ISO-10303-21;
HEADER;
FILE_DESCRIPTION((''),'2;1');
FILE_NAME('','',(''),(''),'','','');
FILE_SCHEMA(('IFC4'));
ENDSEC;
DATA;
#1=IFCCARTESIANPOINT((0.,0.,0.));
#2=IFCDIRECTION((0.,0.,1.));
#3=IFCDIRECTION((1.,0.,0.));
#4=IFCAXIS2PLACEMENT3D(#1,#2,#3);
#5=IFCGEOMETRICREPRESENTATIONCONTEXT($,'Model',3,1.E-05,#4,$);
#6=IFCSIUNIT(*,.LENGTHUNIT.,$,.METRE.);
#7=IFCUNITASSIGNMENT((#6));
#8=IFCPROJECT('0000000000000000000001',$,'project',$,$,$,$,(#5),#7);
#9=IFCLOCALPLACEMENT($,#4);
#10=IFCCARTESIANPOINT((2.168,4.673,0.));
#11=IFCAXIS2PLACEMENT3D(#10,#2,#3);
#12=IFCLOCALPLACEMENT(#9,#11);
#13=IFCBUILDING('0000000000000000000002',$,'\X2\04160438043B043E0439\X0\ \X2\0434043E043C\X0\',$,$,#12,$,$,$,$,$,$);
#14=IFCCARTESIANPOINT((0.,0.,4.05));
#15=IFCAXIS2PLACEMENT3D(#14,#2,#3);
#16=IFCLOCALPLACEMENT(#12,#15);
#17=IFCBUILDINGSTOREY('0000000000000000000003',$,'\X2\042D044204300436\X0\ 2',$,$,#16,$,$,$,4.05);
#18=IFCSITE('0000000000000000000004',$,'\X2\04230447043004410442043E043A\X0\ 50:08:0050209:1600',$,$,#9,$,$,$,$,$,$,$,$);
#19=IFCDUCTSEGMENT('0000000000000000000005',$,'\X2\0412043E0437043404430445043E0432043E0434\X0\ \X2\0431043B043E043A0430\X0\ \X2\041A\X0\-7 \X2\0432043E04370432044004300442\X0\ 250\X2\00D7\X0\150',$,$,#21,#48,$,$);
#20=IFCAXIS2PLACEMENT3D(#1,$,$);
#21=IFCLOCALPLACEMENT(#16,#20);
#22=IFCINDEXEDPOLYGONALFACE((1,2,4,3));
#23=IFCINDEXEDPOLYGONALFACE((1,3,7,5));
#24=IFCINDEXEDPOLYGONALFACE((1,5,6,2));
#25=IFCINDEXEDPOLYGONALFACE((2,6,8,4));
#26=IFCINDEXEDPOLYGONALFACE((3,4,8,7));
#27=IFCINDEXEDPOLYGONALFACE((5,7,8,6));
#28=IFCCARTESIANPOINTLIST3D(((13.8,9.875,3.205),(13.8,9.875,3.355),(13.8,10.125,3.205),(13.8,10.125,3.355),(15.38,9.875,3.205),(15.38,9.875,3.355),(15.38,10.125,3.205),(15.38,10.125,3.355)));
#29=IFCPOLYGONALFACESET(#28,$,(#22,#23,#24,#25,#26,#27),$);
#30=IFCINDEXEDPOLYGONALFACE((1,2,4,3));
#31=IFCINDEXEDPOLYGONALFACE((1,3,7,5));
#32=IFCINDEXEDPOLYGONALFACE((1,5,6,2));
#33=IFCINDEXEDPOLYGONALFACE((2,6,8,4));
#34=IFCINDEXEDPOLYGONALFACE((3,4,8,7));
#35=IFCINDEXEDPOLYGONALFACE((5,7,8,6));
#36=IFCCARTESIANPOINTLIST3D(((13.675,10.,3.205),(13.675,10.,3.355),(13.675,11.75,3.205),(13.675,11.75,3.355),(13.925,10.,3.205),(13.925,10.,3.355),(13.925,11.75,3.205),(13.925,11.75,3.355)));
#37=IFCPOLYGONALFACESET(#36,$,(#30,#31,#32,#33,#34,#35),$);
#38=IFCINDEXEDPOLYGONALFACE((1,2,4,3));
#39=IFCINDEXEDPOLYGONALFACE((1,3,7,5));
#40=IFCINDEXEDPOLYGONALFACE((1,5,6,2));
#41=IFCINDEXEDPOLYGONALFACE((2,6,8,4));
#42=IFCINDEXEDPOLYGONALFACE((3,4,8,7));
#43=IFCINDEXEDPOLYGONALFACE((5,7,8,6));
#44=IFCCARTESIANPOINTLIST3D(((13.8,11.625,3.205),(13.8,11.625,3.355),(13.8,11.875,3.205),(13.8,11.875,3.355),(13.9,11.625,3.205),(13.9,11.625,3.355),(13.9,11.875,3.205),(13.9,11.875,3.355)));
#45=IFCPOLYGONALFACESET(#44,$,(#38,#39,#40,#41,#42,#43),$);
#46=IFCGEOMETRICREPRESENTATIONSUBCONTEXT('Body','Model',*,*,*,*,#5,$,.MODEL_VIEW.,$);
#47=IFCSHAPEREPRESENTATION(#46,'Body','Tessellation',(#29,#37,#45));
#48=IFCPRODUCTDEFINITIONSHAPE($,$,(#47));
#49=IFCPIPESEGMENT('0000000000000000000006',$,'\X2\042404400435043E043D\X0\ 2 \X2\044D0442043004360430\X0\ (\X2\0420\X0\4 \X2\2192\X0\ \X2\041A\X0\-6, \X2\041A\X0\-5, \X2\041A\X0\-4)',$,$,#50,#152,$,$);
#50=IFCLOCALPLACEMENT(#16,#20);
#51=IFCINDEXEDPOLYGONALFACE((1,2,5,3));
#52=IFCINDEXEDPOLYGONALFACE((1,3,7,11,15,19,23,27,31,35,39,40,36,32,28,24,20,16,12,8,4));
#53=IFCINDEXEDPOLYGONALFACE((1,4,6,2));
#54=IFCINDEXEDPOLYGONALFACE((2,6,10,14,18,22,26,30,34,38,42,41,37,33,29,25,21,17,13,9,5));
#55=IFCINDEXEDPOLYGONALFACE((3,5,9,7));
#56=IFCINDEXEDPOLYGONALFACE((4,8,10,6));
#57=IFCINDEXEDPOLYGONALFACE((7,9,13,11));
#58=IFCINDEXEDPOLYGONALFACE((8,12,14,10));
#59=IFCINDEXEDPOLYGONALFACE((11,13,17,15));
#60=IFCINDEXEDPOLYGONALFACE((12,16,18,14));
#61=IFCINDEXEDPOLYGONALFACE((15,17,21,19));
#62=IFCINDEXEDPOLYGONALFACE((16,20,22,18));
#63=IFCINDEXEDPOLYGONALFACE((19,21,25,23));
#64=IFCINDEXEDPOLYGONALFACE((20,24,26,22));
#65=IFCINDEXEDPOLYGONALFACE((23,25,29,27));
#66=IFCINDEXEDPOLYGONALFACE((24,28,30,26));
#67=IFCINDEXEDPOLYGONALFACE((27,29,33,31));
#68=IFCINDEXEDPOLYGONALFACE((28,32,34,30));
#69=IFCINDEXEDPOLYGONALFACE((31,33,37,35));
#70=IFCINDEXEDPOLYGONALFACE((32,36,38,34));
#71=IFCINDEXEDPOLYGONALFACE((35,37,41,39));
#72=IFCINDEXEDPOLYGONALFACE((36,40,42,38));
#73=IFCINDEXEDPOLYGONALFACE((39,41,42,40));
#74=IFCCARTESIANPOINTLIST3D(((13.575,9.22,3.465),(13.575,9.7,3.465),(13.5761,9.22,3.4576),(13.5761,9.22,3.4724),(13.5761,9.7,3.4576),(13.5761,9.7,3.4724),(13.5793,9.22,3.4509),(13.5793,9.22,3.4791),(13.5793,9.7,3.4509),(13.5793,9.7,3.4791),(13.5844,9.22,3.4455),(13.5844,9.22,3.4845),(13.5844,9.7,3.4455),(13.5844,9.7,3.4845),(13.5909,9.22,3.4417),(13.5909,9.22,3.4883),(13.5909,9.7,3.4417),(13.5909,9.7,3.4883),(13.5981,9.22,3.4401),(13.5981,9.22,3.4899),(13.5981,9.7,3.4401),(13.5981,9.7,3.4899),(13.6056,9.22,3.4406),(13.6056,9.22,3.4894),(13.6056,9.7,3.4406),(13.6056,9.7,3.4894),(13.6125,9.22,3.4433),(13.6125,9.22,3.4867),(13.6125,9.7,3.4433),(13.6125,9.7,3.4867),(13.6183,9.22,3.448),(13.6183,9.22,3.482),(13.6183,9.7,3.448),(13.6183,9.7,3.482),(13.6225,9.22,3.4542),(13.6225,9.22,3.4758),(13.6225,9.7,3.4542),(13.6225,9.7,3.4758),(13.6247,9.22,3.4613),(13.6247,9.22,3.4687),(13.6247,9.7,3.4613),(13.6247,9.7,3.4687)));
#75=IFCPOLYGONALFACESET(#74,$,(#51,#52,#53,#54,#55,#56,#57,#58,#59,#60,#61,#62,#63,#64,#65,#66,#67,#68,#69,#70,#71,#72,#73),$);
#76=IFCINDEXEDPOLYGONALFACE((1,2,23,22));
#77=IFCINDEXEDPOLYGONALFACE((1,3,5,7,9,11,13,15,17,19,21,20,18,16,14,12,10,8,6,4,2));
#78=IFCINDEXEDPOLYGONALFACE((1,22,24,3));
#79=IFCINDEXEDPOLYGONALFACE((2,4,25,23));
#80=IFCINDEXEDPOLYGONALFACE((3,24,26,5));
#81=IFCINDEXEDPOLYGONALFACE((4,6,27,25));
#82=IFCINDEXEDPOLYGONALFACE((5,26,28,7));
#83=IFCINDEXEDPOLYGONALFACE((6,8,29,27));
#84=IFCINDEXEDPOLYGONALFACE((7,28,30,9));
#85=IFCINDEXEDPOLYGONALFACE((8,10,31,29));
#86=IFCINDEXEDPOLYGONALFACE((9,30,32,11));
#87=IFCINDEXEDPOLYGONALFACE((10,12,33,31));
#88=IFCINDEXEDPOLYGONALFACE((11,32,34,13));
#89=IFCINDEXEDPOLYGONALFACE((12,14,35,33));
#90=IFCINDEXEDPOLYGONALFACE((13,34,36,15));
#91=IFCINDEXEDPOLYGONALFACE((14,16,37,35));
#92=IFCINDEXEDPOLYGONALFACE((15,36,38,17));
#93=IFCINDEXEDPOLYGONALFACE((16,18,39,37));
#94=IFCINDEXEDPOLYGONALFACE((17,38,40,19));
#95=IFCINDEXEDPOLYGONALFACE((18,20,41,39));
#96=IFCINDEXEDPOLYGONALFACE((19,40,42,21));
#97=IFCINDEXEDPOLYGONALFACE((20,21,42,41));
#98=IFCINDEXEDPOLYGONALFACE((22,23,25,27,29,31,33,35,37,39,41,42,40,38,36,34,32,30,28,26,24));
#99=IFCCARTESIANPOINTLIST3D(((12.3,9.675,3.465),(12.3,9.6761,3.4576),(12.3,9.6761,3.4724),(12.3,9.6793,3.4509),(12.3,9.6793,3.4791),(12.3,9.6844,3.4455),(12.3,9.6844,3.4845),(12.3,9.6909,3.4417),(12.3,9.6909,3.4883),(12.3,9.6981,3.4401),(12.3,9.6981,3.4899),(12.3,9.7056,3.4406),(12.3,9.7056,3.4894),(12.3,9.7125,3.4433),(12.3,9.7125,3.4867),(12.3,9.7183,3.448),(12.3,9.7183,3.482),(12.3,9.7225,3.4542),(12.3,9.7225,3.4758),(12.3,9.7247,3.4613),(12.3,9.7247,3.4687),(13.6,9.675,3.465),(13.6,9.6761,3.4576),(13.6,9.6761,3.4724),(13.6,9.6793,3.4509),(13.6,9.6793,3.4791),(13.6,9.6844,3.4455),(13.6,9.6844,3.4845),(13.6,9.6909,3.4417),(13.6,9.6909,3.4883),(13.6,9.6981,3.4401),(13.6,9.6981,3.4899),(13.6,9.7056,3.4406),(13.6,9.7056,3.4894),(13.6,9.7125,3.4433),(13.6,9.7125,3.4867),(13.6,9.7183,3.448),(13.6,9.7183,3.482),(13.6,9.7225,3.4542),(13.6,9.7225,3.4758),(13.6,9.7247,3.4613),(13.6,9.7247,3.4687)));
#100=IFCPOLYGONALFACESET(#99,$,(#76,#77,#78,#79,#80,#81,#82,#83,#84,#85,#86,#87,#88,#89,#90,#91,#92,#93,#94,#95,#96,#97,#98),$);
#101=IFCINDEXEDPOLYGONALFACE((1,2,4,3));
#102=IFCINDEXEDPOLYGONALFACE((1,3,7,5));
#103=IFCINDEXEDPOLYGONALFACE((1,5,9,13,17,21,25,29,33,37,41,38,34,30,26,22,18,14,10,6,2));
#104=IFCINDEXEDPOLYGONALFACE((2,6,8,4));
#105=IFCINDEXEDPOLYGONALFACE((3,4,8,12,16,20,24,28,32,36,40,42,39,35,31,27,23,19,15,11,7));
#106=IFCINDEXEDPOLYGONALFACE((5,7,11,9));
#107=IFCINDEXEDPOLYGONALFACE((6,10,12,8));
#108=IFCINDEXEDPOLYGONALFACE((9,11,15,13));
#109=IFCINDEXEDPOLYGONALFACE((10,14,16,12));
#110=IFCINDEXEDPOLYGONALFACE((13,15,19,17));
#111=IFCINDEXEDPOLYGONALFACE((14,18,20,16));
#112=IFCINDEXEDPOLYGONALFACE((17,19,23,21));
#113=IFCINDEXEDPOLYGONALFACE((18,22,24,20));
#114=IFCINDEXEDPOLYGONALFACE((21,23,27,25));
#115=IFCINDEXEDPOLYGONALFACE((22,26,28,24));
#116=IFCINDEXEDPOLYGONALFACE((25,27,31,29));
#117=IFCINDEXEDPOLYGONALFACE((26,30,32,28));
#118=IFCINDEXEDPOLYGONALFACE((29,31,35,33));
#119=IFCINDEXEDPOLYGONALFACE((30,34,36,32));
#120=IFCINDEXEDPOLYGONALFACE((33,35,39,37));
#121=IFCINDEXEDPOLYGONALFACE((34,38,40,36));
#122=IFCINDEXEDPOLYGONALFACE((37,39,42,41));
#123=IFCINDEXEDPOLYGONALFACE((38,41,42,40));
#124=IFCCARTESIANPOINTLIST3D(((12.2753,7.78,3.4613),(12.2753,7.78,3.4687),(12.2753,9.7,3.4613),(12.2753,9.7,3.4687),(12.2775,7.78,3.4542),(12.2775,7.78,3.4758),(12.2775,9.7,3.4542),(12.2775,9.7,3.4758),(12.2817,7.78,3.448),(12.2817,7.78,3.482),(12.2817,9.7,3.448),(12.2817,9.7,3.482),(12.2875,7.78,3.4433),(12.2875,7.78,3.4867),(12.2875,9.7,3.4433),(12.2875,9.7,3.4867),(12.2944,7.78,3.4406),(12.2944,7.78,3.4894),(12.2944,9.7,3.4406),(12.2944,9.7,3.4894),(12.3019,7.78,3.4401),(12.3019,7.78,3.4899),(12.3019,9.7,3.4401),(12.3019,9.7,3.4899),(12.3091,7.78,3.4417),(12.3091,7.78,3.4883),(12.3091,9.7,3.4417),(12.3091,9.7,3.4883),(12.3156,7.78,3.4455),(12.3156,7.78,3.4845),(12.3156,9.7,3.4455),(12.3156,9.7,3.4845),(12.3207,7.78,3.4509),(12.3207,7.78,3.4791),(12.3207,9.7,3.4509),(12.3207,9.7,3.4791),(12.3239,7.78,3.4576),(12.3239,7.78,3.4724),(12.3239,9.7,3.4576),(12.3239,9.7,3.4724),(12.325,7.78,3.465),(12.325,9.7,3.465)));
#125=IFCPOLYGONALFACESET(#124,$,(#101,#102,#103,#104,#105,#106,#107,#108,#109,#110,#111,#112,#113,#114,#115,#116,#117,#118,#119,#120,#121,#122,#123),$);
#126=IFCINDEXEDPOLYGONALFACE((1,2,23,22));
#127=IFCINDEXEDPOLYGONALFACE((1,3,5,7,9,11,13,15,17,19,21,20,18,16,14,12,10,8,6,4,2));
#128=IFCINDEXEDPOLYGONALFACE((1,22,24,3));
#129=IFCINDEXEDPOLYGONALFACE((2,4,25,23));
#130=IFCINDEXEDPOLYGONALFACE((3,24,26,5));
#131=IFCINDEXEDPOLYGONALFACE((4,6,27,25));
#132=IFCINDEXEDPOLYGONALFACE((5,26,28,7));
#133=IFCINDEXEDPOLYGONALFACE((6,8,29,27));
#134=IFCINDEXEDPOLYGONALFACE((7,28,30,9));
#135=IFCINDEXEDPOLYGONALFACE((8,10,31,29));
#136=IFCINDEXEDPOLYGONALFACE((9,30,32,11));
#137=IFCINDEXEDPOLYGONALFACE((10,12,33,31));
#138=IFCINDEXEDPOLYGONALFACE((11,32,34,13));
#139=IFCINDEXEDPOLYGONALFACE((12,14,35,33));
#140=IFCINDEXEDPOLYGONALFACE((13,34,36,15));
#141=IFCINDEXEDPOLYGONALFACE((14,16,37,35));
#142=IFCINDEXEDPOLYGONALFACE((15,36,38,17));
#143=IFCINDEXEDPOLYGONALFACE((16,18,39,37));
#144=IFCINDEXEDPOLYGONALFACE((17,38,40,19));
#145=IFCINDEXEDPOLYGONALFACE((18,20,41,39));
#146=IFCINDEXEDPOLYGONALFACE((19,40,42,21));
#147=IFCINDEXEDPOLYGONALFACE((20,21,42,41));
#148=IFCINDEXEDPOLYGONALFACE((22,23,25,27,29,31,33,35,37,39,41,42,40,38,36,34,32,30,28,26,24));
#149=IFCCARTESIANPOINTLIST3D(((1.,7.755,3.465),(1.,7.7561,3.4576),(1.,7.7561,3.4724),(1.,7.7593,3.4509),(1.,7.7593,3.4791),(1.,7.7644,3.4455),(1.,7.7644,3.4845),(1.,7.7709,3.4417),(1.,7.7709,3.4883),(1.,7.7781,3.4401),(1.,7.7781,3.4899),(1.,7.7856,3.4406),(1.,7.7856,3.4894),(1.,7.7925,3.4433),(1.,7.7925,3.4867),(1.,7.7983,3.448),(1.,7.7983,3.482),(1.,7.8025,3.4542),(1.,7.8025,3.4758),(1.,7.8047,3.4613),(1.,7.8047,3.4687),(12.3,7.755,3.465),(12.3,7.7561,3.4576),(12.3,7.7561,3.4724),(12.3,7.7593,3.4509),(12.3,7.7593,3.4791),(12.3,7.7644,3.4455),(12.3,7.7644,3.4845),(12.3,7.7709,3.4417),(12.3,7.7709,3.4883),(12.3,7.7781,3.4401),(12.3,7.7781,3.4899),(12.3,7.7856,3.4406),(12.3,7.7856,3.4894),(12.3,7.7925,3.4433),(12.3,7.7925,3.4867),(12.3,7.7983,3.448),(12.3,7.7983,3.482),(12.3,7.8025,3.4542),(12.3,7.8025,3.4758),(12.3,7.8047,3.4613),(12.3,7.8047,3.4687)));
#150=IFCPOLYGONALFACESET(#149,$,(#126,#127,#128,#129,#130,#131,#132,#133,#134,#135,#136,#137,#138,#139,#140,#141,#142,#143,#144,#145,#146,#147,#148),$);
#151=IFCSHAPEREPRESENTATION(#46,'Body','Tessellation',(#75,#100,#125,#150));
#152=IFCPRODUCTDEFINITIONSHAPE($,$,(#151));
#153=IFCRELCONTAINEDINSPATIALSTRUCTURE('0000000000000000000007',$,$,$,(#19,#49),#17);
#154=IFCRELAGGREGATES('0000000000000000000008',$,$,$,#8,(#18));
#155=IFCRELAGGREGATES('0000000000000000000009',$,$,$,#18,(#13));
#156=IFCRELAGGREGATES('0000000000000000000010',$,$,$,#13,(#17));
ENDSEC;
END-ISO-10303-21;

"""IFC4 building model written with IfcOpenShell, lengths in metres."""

from ifc_helpers import new_model, si_unit, frame, origin_with_axes, origin_2d, place, context, subcontext, project, spatial, rectangle, circle, extrude, element, save


model = new_model("IFC4")

# Units and contexts
model_context = context("Model", 3, precision=1e-05, world=origin_with_axes())
body_context = subcontext(model_context, "Body", "Model", "MODEL_VIEW")
ifc_project = project(units=[si_unit("LENGTHUNIT", "METRE")], contexts=[model_context])

# Site, building, storey
site_placement = place(None, origin_with_axes())
site = spatial("IfcSite", under=ifc_project, at=site_placement, Name="Участок 50:08:0050209:1600")
building_placement = place(site_placement, frame((2.168, 4.673, 0.0), z_axis=(0.0, 0.0, 1.0), x_axis=(1.0, 0.0, 0.0)))
building = spatial("IfcBuilding", under=site, at=building_placement, Name="Жилой дом")
storey_placement = place(building_placement, frame((0.0, 0.0, 4.05), z_axis=(0.0, 0.0, 1.0), x_axis=(1.0, 0.0, 0.0)))
storey = spatial("IfcBuildingStorey", under=building, at=storey_placement, Name="Этаж 2", Elevation=4.05)

# Duct segment
duct_segment_1_placement = place(storey_placement, frame((0.0, 0.0, -4.05), z_axis=(0.0, 0.0, 1.0), x_axis=(1.0, 0.0, 0.0)))
element("IfcDuctSegment", 1, at=duct_segment_1_placement, inside=storey, Name="Воздуховод блока К-7 возврат 250×150", context=body_context, shape_type="SweptSolid", body=[
    extrude(rectangle(XDim=0.25, YDim=0.15, at=origin_2d()), frame((15.38, 10.0, 7.33), z_axis=(-1.0, 0.0, 0.0), x_axis=(0.0, -1.0, 0.0)), (0.0, 0.0, 1.0), 1.58),
    extrude(rectangle(XDim=0.25, YDim=0.15, at=origin_2d()), frame((13.8, 10.0, 7.33), z_axis=(0.0, 1.0, 0.0), x_axis=(-1.0, 0.0, 0.0)), (0.0, 0.0, 1.0), 1.75),
    extrude(rectangle(XDim=0.25, YDim=0.15, at=origin_2d()), frame((13.8, 11.75, 7.33), z_axis=(1.0, 0.0, 0.0), x_axis=(0.0, 1.0, 0.0)), (0.0, 0.0, 1.0), 0.1),
])

# Pipe segment
pipe_segment_1_placement = place(storey_placement, frame((0.0, 0.0, -4.05), z_axis=(0.0, 0.0, 1.0), x_axis=(1.0, 0.0, 0.0)))
element("IfcPipeSegment", 2, at=pipe_segment_1_placement, inside=storey, Name="Фреон 2 этажа (Р4 → К-6, К-5, К-4)", context=body_context, shape_type="SweptSolid", body=[
    extrude(circle(Radius=0.025, at=origin_2d()), frame((13.6, 9.22, 7.515), z_axis=(0.0, 1.0, 0.0), x_axis=(-1.0, 0.0, 0.0)), (0.0, 0.0, 1.0), 0.48),
    extrude(circle(Radius=0.025, at=origin_2d()), frame((13.6, 9.7, 7.515), z_axis=(-1.0, 0.0, 0.0), x_axis=(0.0, -1.0, 0.0)), (0.0, 0.0, 1.0), 1.3),
    extrude(circle(Radius=0.025, at=origin_2d()), frame((12.3, 9.7, 7.515), z_axis=(0.0, -1.0, 0.0), x_axis=(1.0, 0.0, 0.0)), (0.0, 0.0, 1.0), 1.92),
    extrude(circle(Radius=0.025, at=origin_2d()), frame((12.3, 7.78, 7.515), z_axis=(-1.0, 0.0, 0.0), x_axis=(0.0, -1.0, 0.0)), (0.0, 0.0, 1.0), 11.3),
])

save(model, "model.ifc")
